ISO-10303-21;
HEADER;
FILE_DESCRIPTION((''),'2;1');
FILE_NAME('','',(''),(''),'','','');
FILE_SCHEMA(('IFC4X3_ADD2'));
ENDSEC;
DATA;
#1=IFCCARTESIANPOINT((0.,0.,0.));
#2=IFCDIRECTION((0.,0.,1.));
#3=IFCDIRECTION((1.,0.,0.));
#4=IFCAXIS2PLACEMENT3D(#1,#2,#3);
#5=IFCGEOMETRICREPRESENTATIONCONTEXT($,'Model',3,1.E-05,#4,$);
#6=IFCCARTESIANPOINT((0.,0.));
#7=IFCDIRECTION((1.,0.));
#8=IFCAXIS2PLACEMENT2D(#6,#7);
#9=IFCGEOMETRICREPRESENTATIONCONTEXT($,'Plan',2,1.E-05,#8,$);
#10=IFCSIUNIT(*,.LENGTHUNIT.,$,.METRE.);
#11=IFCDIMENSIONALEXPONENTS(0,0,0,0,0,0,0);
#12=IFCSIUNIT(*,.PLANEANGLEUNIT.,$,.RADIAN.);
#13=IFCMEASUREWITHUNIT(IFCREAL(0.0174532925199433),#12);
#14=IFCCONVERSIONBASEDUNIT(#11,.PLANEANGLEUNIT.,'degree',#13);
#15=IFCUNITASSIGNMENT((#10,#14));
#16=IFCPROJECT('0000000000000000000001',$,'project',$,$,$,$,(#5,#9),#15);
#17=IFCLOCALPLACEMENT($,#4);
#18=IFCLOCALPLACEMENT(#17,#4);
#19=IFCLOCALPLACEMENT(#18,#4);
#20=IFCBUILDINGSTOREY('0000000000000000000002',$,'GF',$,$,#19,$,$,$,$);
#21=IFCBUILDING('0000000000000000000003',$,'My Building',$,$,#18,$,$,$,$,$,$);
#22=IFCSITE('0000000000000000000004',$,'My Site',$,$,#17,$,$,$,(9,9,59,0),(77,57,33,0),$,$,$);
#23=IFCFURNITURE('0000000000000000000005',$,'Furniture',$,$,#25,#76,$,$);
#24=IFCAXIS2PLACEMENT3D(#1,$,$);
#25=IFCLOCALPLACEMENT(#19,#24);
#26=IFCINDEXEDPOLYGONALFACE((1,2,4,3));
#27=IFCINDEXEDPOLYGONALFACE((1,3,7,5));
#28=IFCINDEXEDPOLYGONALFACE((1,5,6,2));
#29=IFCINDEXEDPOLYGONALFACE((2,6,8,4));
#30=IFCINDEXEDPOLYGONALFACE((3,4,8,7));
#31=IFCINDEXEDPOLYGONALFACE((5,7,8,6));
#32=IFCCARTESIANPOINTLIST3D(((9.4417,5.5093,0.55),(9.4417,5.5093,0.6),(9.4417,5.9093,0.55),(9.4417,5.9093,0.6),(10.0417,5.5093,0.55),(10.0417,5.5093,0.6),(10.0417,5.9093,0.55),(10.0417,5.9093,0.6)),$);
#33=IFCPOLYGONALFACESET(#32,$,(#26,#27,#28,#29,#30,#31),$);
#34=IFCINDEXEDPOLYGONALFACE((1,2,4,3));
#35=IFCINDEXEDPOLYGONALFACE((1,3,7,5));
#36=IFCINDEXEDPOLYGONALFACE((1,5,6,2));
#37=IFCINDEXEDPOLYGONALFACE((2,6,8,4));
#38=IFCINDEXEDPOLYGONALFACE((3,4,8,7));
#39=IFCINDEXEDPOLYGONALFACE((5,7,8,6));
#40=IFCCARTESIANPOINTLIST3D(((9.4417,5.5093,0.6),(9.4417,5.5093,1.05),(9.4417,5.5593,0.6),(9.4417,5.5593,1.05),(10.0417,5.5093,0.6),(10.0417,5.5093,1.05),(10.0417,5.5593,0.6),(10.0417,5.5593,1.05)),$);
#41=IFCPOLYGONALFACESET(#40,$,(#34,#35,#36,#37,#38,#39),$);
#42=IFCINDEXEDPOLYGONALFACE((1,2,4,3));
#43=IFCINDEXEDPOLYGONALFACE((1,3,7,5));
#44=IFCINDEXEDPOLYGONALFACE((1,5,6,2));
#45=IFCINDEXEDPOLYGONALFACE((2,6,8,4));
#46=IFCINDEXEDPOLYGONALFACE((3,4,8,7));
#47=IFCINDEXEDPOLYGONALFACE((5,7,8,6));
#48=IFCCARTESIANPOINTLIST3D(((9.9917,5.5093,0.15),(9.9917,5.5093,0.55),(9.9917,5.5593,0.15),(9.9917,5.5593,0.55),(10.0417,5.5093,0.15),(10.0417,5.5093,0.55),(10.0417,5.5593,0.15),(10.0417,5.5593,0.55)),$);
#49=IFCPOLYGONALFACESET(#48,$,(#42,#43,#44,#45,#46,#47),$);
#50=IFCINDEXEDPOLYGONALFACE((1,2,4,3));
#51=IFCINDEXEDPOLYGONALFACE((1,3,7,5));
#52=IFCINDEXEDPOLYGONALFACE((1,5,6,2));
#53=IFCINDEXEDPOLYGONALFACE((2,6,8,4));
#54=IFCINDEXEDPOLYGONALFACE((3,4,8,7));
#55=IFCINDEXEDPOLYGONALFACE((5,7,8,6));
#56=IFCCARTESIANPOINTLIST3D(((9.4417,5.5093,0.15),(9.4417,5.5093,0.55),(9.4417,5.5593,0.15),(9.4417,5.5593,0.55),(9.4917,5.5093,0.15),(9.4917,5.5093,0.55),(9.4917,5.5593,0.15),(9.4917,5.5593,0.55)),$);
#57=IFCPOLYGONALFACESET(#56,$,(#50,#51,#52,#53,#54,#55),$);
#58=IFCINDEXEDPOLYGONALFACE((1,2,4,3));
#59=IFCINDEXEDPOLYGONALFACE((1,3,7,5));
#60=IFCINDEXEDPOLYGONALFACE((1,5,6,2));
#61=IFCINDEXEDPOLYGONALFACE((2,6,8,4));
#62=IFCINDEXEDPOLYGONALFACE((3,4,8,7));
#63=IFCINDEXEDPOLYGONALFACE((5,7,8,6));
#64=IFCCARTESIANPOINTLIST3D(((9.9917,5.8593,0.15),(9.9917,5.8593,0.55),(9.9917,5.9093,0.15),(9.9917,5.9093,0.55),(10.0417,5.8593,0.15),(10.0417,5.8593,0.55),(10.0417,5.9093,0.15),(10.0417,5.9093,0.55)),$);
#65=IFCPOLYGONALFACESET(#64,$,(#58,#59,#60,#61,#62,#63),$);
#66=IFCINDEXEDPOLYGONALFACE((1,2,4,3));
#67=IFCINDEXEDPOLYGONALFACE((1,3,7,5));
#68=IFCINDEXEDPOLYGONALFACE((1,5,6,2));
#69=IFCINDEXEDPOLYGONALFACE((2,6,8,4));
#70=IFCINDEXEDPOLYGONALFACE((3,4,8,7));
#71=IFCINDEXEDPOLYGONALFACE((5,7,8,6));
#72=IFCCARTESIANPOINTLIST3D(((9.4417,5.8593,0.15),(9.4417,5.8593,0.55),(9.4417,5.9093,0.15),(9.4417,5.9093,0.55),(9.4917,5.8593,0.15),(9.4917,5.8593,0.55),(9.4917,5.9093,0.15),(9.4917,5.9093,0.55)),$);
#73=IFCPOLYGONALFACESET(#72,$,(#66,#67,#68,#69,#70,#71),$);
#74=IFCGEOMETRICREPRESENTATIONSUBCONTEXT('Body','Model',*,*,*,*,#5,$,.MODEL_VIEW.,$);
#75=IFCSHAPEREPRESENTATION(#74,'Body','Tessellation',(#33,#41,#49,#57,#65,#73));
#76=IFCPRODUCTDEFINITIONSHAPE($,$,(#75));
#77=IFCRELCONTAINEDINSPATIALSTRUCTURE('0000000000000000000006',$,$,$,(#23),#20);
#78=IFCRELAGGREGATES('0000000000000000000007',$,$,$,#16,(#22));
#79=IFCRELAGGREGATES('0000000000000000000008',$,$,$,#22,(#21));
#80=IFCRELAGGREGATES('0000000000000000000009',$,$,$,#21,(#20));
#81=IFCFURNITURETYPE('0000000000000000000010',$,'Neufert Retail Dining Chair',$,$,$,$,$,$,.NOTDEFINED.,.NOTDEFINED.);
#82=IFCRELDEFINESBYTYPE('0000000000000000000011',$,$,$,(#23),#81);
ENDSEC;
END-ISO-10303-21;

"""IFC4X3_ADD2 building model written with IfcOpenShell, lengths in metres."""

from ifc_helpers import new_model, entity, si_unit, converted_unit, frame, origin_with_axes, origin_2d_with_axis, place, context, subcontext, project, spatial, line, indexed_curve, outline, extrude, shape, source, transform, mapped, type_object, type_shapes, element, save


model = new_model("IFC4X3_ADD2")

# Units and contexts
model_context = context("Model", 3, precision=1e-05, world=origin_with_axes())
plan_context = context("Plan", 2, precision=1e-05, world=origin_2d_with_axis())
body_context_1 = subcontext(model_context, "Body", "Model", "MODEL_VIEW")
body_context_2 = subcontext(plan_context, "Body", "Plan", "PLAN_VIEW")
ifc_project = project(units=[si_unit("LENGTHUNIT", "METRE"), converted_unit("PLANEANGLEUNIT", "degree", entity("IfcReal", 0.0174532925199433), si_unit("PLANEANGLEUNIT", "RADIAN"), dimensions=[0, 0, 0, 0, 0, 0, 0])], contexts=[model_context, plan_context])

# Site, building, storey
site_placement = place(None, origin_with_axes())
site = spatial("IfcSite", under=ifc_project, at=site_placement, Name="My Site", RefLatitude=(9, 9, 59, 0), RefLongitude=(77, 57, 33, 0))
building_placement = place(site_placement, origin_with_axes())
building = spatial("IfcBuilding", under=site, at=building_placement, Name="My Building")
storey_placement = place(building_placement, origin_with_axes())
storey = spatial("IfcBuildingStorey", under=building, at=storey_placement, Name="GF")

# Furniture
furniture_type = type_object("IfcFurnitureType", Name="Neufert Retail Dining Chair", AssemblyPlace="NOTDEFINED", PredefinedType="NOTDEFINED")
shared_shape_1 = source(origin_with_axes(), body_context_1, "Body", "SweptSolid", [
    extrude(outline(indexed_curve([(-0.3, 0.0), (0.3, 0.0), (0.3, -0.4), (-0.3, -0.4)], segments=[line(1, 2, 3, 4, 1)])), frame((0.0, 0.0, 0.45), z_axis=(0.0, 0.0, 1.0), x_axis=(1.0, 0.0, 0.0)), (0.0, 0.0, -1.0), 0.05),
    extrude(outline(indexed_curve([(-0.3, 0.0), (0.3, 0.0), (0.3, -0.05), (-0.3, -0.05)], segments=[line(1, 2, 3, 4, 1)])), frame((0.0, 0.0, 0.9), z_axis=(0.0, 0.0, 1.0), x_axis=(1.0, 0.0, 0.0)), (0.0, 0.0, -1.0), 0.45),
    extrude(outline(indexed_curve([(-0.3, 0.0), (-0.25, 0.0), (-0.25, -0.05), (-0.3, -0.05)], segments=[line(1, 2, 3, 4, 1)])), origin_with_axes(), (0.0, 0.0, 1.0), 0.4),
    extrude(outline(indexed_curve([(0.3, 0.0), (0.25, 0.0), (0.25, -0.05), (0.3, -0.05)], segments=[line(1, 2, 3, 4, 1)])), origin_with_axes(), (0.0, 0.0, 1.0), 0.4),
    extrude(outline(indexed_curve([(-0.3, -0.4), (-0.25, -0.4), (-0.25, -0.35), (-0.3, -0.35)], segments=[line(1, 2, 3, 4, 1)])), origin_with_axes(), (0.0, 0.0, 1.0), 0.4),
    extrude(outline(indexed_curve([(0.3, -0.4), (0.25, -0.4), (0.25, -0.35), (0.3, -0.35)], segments=[line(1, 2, 3, 4, 1)])), origin_with_axes(), (0.0, 0.0, 1.0), 0.4),
])
shared_shape_2 = source(origin_with_axes(), body_context_2, "Body", "Curve2D", [
    entity("IfcIndexedPolyCurve", entity("IfcCartesianPointList2D", [[-0.3, -0.4], [0.3, -0.4]])),
    entity("IfcIndexedPolyCurve", entity("IfcCartesianPointList2D", [[-0.3, -0.4], [-0.3, -0.3], [-0.2121, -0.0879], [0.0, 0.0], [0.2121, -0.0879], [0.3, -0.3], [0.3, -0.4]]), [entity("IfcLineIndex", [1, 2]), entity("IfcArcIndex", [2, 3, 4]), entity("IfcArcIndex", [4, 5, 6]), entity("IfcLineIndex", [6, 7])]),
    entity("IfcIndexedPolyCurve", entity("IfcCartesianPointList2D", [[-0.26, -0.4], [-0.26, -0.3], [-0.1838, -0.1162], [0.0, -0.04], [0.1838, -0.1162], [0.26, -0.3], [0.26, -0.4]]), [entity("IfcLineIndex", [1, 2]), entity("IfcArcIndex", [2, 3, 4]), entity("IfcArcIndex", [4, 5, 6]), entity("IfcLineIndex", [6, 7])]),
])
type_shapes(furniture_type, [shared_shape_1, shared_shape_2])
for number, where, z_axis, x_axis, name in (
    (1, (9.7417, 5.5093, 0.15), (0.0, 0.0, 1.0), (-1.0, 0.000002, 0.0), "Furniture"),
):
    element("IfcFurniture", number, at=place(storey_placement, frame(where, z_axis=z_axis, x_axis=x_axis)), inside=storey, type_object=furniture_type, Name=name, shapes=[
        shape(body_context_1, "Body", "MappedRepresentation", [mapped(shared_shape_1, transform((0.0, 0.0, 0.0), x_axis=(1.0, 0.0, 0.0), y_axis=(0.0, 1.0, 0.0), z_axis=(0.0, 0.0, 1.0), scale=1.0))]),
        shape(body_context_2, "Body", "MappedRepresentation", [mapped(shared_shape_2, transform((0.0, 0.0, 0.0), x_axis=(1.0, 0.0, 0.0), y_axis=(0.0, 1.0, 0.0), z_axis=(0.0, 0.0, 1.0), scale=1.0))]),
    ])

save(model, "model.ifc")
